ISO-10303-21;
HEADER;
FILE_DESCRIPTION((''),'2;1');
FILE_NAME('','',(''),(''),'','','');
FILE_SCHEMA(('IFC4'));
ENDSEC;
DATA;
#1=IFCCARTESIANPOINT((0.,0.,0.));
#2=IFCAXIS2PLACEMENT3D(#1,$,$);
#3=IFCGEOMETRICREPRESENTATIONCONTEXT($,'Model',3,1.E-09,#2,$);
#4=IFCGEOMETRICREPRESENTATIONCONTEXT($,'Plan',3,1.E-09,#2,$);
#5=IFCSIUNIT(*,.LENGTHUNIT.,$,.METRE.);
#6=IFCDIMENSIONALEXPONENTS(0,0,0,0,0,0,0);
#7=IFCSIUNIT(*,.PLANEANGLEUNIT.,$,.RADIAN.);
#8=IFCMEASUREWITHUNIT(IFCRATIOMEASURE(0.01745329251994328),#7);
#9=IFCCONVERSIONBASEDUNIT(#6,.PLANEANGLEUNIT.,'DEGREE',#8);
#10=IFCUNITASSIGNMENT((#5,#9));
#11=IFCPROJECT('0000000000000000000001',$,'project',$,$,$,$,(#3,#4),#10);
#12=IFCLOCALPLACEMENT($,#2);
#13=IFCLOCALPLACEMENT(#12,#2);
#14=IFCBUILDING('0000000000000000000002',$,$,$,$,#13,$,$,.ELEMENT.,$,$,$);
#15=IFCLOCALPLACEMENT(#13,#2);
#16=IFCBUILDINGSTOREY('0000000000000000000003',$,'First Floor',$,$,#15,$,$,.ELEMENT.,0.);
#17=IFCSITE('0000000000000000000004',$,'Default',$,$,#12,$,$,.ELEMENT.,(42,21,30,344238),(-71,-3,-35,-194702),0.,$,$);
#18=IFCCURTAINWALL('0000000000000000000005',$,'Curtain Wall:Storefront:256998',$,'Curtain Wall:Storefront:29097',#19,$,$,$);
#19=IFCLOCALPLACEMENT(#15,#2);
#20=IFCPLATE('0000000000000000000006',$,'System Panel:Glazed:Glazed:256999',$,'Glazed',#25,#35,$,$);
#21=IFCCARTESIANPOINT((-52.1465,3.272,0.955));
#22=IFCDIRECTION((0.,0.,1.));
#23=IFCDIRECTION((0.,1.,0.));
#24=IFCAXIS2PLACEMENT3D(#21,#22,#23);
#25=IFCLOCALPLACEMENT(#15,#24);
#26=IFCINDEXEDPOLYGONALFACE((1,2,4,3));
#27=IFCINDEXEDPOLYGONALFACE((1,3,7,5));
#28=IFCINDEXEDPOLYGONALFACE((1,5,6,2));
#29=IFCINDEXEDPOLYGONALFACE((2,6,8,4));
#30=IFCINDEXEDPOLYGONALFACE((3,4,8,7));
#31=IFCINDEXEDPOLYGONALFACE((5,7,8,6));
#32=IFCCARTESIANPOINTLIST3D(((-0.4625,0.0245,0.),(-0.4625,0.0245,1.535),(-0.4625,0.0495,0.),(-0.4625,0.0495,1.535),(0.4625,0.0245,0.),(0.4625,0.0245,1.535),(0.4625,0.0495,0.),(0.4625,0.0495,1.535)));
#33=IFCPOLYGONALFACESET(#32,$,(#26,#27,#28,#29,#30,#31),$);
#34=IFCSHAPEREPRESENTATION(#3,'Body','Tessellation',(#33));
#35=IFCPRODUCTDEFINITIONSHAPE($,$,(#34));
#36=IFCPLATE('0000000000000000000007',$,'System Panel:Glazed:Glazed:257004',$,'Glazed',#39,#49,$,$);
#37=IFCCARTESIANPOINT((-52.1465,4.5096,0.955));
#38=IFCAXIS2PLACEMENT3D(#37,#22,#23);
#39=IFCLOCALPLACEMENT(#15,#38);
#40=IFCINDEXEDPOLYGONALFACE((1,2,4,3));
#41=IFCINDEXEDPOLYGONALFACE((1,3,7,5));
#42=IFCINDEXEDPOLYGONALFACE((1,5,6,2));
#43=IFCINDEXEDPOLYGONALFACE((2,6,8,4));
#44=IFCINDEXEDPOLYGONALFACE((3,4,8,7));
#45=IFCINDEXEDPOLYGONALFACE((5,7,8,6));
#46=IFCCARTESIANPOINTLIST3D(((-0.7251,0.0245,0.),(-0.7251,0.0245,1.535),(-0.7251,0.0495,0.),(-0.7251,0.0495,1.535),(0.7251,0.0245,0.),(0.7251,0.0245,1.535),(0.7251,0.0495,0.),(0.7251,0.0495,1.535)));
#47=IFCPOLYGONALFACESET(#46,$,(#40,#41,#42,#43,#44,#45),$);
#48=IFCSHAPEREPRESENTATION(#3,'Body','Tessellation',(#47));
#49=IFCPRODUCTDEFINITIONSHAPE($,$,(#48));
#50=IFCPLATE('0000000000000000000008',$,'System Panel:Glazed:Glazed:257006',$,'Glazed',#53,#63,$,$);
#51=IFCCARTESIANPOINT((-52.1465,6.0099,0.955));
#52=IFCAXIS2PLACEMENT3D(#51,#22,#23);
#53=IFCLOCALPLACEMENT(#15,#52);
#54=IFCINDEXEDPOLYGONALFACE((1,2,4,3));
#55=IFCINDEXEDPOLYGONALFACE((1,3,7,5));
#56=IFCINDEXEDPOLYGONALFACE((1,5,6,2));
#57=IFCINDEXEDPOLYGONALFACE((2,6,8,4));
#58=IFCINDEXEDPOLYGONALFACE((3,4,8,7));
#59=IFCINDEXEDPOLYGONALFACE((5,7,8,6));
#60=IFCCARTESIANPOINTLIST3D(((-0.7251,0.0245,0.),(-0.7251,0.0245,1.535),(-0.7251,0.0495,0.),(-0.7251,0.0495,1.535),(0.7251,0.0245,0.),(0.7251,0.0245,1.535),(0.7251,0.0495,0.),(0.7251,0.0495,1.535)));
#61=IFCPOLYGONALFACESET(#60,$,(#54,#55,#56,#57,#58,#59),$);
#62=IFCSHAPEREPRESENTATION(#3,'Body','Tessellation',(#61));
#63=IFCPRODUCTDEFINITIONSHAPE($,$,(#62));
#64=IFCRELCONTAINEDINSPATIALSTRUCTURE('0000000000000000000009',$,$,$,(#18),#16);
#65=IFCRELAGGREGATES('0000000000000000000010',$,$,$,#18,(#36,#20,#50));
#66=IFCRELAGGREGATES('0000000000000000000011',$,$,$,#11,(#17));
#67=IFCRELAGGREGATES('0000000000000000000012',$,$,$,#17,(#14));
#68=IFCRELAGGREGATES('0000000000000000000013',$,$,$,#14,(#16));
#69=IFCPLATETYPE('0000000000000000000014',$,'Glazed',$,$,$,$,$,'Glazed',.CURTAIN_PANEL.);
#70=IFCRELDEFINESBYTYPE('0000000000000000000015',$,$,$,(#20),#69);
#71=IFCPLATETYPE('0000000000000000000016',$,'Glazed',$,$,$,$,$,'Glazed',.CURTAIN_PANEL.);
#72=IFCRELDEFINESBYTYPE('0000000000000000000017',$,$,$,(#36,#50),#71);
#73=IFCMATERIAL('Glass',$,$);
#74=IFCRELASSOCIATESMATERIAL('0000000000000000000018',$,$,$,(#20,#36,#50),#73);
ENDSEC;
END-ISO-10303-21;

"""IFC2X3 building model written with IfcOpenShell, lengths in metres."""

from ifc_helpers import new_model, entity, si_unit, converted_unit, frame, origin, origin_2d_with_axis, place, context, project, spatial, rectangle, extrude, source, transform, mapped, material, type_object, type_shapes, element, aggregate, save


model = new_model("IFC2X3")

# Units and contexts
model_context = context("Model", 3, precision=1e-09, world=origin())
plan_context = context("Plan", 3, precision=1e-09, world=origin())
ifc_project = project(units=[si_unit("LENGTHUNIT", "METRE"), converted_unit("PLANEANGLEUNIT", "DEGREE", entity("IfcRatioMeasure", 0.01745329251994328), si_unit("PLANEANGLEUNIT", "RADIAN"), dimensions=[0, 0, 0, 0, 0, 0, 0])], contexts=[model_context, plan_context])

# Site, building, storey
site_placement = place(None, origin())
site = spatial("IfcSite", under=ifc_project, at=site_placement, Name="Default", CompositionType="ELEMENT", RefLatitude=(42, 21, 30, 344238), RefLongitude=(-71, -3, -35, -194702), RefElevation=0.0)
building_placement = place(site_placement, origin())
building = spatial("IfcBuilding", under=site, at=building_placement, CompositionType="ELEMENT")
storey_placement = place(building_placement, origin())
storey = spatial("IfcBuildingStorey", under=building, at=storey_placement, Name="First Floor", CompositionType="ELEMENT", Elevation=0.0)

# Curtain wall, plates
curtain_wall_placement = place(storey_placement, origin())
curtain_wall = element("IfcCurtainWall", 1, at=curtain_wall_placement, inside=storey, Name="Curtain Wall:Storefront:256998", ObjectType="Curtain Wall:Storefront:29097")
ifc_material_1 = material(Name="Glass")
plate_type_1 = type_object("IfcPlateType", Name="Glazed", ElementType="Glazed", PredefinedType="CURTAIN_PANEL")
shared_shape_1 = source(origin(), model_context, "Body", "SweptSolid", [
    extrude(rectangle(XDim=0.025, YDim=0.925, at=origin_2d_with_axis()), frame((0.0, 0.037, 0.0), z_axis=(0.0, 0.0, 1.0), x_axis=(0.0, 1.0, 0.0)), (0.0, 0.0, 1.0), 1.535),
])
type_shapes(plate_type_1, [shared_shape_1])
plate_1_placement = place(storey_placement, frame((-52.1465, 3.272, 0.955), z_axis=(0.0, 0.0, 1.0), x_axis=(0.0, 1.0, 0.0)))
plate_1 = element("IfcPlate", 2, at=plate_1_placement, type_object=plate_type_1, material=ifc_material_1, Name="System Panel:Glazed:Glazed:256999", ObjectType="Glazed", context=model_context, shape_type="MappedRepresentation", body=[
    mapped(shared_shape_1, transform((0.0, 0.0, 0.0), scale=1.0)),
])
plate_type_2 = type_object("IfcPlateType", Name="Glazed", ElementType="Glazed", PredefinedType="CURTAIN_PANEL")
shared_shape_2 = source(origin(), model_context, "Body", "SweptSolid", [
    extrude(rectangle(XDim=0.025, YDim=1.4503, at=origin_2d_with_axis()), frame((0.0, 0.037, 0.0), z_axis=(0.0, 0.0, 1.0), x_axis=(0.0, 1.0, 0.0)), (0.0, 0.0, 1.0), 1.535),
])
type_shapes(plate_type_2, [shared_shape_2])
plate_2_placement = place(storey_placement, frame((-52.1465, 4.5096, 0.955), z_axis=(0.0, 0.0, 1.0), x_axis=(0.0, 1.0, 0.0)))
plate_2 = element("IfcPlate", 3, at=plate_2_placement, type_object=plate_type_2, material=ifc_material_1, Name="System Panel:Glazed:Glazed:257004", ObjectType="Glazed", context=model_context, shape_type="MappedRepresentation", body=[
    mapped(shared_shape_2, transform((0.0, 0.0, 0.0), scale=1.0)),
])
plate_3_placement = place(storey_placement, frame((-52.1465, 6.0099, 0.955), z_axis=(0.0, 0.0, 1.0), x_axis=(0.0, 1.0, 0.0)))
plate_3 = element("IfcPlate", 4, at=plate_3_placement, type_object=plate_type_2, material=ifc_material_1, Name="System Panel:Glazed:Glazed:257006", ObjectType="Glazed", context=model_context, shape_type="MappedRepresentation", body=[
    mapped(shared_shape_2, transform((0.0, 0.0, 0.0), scale=1.0)),
])
aggregate(curtain_wall, [plate_2, plate_1, plate_3])

save(model, "model.ifc")
